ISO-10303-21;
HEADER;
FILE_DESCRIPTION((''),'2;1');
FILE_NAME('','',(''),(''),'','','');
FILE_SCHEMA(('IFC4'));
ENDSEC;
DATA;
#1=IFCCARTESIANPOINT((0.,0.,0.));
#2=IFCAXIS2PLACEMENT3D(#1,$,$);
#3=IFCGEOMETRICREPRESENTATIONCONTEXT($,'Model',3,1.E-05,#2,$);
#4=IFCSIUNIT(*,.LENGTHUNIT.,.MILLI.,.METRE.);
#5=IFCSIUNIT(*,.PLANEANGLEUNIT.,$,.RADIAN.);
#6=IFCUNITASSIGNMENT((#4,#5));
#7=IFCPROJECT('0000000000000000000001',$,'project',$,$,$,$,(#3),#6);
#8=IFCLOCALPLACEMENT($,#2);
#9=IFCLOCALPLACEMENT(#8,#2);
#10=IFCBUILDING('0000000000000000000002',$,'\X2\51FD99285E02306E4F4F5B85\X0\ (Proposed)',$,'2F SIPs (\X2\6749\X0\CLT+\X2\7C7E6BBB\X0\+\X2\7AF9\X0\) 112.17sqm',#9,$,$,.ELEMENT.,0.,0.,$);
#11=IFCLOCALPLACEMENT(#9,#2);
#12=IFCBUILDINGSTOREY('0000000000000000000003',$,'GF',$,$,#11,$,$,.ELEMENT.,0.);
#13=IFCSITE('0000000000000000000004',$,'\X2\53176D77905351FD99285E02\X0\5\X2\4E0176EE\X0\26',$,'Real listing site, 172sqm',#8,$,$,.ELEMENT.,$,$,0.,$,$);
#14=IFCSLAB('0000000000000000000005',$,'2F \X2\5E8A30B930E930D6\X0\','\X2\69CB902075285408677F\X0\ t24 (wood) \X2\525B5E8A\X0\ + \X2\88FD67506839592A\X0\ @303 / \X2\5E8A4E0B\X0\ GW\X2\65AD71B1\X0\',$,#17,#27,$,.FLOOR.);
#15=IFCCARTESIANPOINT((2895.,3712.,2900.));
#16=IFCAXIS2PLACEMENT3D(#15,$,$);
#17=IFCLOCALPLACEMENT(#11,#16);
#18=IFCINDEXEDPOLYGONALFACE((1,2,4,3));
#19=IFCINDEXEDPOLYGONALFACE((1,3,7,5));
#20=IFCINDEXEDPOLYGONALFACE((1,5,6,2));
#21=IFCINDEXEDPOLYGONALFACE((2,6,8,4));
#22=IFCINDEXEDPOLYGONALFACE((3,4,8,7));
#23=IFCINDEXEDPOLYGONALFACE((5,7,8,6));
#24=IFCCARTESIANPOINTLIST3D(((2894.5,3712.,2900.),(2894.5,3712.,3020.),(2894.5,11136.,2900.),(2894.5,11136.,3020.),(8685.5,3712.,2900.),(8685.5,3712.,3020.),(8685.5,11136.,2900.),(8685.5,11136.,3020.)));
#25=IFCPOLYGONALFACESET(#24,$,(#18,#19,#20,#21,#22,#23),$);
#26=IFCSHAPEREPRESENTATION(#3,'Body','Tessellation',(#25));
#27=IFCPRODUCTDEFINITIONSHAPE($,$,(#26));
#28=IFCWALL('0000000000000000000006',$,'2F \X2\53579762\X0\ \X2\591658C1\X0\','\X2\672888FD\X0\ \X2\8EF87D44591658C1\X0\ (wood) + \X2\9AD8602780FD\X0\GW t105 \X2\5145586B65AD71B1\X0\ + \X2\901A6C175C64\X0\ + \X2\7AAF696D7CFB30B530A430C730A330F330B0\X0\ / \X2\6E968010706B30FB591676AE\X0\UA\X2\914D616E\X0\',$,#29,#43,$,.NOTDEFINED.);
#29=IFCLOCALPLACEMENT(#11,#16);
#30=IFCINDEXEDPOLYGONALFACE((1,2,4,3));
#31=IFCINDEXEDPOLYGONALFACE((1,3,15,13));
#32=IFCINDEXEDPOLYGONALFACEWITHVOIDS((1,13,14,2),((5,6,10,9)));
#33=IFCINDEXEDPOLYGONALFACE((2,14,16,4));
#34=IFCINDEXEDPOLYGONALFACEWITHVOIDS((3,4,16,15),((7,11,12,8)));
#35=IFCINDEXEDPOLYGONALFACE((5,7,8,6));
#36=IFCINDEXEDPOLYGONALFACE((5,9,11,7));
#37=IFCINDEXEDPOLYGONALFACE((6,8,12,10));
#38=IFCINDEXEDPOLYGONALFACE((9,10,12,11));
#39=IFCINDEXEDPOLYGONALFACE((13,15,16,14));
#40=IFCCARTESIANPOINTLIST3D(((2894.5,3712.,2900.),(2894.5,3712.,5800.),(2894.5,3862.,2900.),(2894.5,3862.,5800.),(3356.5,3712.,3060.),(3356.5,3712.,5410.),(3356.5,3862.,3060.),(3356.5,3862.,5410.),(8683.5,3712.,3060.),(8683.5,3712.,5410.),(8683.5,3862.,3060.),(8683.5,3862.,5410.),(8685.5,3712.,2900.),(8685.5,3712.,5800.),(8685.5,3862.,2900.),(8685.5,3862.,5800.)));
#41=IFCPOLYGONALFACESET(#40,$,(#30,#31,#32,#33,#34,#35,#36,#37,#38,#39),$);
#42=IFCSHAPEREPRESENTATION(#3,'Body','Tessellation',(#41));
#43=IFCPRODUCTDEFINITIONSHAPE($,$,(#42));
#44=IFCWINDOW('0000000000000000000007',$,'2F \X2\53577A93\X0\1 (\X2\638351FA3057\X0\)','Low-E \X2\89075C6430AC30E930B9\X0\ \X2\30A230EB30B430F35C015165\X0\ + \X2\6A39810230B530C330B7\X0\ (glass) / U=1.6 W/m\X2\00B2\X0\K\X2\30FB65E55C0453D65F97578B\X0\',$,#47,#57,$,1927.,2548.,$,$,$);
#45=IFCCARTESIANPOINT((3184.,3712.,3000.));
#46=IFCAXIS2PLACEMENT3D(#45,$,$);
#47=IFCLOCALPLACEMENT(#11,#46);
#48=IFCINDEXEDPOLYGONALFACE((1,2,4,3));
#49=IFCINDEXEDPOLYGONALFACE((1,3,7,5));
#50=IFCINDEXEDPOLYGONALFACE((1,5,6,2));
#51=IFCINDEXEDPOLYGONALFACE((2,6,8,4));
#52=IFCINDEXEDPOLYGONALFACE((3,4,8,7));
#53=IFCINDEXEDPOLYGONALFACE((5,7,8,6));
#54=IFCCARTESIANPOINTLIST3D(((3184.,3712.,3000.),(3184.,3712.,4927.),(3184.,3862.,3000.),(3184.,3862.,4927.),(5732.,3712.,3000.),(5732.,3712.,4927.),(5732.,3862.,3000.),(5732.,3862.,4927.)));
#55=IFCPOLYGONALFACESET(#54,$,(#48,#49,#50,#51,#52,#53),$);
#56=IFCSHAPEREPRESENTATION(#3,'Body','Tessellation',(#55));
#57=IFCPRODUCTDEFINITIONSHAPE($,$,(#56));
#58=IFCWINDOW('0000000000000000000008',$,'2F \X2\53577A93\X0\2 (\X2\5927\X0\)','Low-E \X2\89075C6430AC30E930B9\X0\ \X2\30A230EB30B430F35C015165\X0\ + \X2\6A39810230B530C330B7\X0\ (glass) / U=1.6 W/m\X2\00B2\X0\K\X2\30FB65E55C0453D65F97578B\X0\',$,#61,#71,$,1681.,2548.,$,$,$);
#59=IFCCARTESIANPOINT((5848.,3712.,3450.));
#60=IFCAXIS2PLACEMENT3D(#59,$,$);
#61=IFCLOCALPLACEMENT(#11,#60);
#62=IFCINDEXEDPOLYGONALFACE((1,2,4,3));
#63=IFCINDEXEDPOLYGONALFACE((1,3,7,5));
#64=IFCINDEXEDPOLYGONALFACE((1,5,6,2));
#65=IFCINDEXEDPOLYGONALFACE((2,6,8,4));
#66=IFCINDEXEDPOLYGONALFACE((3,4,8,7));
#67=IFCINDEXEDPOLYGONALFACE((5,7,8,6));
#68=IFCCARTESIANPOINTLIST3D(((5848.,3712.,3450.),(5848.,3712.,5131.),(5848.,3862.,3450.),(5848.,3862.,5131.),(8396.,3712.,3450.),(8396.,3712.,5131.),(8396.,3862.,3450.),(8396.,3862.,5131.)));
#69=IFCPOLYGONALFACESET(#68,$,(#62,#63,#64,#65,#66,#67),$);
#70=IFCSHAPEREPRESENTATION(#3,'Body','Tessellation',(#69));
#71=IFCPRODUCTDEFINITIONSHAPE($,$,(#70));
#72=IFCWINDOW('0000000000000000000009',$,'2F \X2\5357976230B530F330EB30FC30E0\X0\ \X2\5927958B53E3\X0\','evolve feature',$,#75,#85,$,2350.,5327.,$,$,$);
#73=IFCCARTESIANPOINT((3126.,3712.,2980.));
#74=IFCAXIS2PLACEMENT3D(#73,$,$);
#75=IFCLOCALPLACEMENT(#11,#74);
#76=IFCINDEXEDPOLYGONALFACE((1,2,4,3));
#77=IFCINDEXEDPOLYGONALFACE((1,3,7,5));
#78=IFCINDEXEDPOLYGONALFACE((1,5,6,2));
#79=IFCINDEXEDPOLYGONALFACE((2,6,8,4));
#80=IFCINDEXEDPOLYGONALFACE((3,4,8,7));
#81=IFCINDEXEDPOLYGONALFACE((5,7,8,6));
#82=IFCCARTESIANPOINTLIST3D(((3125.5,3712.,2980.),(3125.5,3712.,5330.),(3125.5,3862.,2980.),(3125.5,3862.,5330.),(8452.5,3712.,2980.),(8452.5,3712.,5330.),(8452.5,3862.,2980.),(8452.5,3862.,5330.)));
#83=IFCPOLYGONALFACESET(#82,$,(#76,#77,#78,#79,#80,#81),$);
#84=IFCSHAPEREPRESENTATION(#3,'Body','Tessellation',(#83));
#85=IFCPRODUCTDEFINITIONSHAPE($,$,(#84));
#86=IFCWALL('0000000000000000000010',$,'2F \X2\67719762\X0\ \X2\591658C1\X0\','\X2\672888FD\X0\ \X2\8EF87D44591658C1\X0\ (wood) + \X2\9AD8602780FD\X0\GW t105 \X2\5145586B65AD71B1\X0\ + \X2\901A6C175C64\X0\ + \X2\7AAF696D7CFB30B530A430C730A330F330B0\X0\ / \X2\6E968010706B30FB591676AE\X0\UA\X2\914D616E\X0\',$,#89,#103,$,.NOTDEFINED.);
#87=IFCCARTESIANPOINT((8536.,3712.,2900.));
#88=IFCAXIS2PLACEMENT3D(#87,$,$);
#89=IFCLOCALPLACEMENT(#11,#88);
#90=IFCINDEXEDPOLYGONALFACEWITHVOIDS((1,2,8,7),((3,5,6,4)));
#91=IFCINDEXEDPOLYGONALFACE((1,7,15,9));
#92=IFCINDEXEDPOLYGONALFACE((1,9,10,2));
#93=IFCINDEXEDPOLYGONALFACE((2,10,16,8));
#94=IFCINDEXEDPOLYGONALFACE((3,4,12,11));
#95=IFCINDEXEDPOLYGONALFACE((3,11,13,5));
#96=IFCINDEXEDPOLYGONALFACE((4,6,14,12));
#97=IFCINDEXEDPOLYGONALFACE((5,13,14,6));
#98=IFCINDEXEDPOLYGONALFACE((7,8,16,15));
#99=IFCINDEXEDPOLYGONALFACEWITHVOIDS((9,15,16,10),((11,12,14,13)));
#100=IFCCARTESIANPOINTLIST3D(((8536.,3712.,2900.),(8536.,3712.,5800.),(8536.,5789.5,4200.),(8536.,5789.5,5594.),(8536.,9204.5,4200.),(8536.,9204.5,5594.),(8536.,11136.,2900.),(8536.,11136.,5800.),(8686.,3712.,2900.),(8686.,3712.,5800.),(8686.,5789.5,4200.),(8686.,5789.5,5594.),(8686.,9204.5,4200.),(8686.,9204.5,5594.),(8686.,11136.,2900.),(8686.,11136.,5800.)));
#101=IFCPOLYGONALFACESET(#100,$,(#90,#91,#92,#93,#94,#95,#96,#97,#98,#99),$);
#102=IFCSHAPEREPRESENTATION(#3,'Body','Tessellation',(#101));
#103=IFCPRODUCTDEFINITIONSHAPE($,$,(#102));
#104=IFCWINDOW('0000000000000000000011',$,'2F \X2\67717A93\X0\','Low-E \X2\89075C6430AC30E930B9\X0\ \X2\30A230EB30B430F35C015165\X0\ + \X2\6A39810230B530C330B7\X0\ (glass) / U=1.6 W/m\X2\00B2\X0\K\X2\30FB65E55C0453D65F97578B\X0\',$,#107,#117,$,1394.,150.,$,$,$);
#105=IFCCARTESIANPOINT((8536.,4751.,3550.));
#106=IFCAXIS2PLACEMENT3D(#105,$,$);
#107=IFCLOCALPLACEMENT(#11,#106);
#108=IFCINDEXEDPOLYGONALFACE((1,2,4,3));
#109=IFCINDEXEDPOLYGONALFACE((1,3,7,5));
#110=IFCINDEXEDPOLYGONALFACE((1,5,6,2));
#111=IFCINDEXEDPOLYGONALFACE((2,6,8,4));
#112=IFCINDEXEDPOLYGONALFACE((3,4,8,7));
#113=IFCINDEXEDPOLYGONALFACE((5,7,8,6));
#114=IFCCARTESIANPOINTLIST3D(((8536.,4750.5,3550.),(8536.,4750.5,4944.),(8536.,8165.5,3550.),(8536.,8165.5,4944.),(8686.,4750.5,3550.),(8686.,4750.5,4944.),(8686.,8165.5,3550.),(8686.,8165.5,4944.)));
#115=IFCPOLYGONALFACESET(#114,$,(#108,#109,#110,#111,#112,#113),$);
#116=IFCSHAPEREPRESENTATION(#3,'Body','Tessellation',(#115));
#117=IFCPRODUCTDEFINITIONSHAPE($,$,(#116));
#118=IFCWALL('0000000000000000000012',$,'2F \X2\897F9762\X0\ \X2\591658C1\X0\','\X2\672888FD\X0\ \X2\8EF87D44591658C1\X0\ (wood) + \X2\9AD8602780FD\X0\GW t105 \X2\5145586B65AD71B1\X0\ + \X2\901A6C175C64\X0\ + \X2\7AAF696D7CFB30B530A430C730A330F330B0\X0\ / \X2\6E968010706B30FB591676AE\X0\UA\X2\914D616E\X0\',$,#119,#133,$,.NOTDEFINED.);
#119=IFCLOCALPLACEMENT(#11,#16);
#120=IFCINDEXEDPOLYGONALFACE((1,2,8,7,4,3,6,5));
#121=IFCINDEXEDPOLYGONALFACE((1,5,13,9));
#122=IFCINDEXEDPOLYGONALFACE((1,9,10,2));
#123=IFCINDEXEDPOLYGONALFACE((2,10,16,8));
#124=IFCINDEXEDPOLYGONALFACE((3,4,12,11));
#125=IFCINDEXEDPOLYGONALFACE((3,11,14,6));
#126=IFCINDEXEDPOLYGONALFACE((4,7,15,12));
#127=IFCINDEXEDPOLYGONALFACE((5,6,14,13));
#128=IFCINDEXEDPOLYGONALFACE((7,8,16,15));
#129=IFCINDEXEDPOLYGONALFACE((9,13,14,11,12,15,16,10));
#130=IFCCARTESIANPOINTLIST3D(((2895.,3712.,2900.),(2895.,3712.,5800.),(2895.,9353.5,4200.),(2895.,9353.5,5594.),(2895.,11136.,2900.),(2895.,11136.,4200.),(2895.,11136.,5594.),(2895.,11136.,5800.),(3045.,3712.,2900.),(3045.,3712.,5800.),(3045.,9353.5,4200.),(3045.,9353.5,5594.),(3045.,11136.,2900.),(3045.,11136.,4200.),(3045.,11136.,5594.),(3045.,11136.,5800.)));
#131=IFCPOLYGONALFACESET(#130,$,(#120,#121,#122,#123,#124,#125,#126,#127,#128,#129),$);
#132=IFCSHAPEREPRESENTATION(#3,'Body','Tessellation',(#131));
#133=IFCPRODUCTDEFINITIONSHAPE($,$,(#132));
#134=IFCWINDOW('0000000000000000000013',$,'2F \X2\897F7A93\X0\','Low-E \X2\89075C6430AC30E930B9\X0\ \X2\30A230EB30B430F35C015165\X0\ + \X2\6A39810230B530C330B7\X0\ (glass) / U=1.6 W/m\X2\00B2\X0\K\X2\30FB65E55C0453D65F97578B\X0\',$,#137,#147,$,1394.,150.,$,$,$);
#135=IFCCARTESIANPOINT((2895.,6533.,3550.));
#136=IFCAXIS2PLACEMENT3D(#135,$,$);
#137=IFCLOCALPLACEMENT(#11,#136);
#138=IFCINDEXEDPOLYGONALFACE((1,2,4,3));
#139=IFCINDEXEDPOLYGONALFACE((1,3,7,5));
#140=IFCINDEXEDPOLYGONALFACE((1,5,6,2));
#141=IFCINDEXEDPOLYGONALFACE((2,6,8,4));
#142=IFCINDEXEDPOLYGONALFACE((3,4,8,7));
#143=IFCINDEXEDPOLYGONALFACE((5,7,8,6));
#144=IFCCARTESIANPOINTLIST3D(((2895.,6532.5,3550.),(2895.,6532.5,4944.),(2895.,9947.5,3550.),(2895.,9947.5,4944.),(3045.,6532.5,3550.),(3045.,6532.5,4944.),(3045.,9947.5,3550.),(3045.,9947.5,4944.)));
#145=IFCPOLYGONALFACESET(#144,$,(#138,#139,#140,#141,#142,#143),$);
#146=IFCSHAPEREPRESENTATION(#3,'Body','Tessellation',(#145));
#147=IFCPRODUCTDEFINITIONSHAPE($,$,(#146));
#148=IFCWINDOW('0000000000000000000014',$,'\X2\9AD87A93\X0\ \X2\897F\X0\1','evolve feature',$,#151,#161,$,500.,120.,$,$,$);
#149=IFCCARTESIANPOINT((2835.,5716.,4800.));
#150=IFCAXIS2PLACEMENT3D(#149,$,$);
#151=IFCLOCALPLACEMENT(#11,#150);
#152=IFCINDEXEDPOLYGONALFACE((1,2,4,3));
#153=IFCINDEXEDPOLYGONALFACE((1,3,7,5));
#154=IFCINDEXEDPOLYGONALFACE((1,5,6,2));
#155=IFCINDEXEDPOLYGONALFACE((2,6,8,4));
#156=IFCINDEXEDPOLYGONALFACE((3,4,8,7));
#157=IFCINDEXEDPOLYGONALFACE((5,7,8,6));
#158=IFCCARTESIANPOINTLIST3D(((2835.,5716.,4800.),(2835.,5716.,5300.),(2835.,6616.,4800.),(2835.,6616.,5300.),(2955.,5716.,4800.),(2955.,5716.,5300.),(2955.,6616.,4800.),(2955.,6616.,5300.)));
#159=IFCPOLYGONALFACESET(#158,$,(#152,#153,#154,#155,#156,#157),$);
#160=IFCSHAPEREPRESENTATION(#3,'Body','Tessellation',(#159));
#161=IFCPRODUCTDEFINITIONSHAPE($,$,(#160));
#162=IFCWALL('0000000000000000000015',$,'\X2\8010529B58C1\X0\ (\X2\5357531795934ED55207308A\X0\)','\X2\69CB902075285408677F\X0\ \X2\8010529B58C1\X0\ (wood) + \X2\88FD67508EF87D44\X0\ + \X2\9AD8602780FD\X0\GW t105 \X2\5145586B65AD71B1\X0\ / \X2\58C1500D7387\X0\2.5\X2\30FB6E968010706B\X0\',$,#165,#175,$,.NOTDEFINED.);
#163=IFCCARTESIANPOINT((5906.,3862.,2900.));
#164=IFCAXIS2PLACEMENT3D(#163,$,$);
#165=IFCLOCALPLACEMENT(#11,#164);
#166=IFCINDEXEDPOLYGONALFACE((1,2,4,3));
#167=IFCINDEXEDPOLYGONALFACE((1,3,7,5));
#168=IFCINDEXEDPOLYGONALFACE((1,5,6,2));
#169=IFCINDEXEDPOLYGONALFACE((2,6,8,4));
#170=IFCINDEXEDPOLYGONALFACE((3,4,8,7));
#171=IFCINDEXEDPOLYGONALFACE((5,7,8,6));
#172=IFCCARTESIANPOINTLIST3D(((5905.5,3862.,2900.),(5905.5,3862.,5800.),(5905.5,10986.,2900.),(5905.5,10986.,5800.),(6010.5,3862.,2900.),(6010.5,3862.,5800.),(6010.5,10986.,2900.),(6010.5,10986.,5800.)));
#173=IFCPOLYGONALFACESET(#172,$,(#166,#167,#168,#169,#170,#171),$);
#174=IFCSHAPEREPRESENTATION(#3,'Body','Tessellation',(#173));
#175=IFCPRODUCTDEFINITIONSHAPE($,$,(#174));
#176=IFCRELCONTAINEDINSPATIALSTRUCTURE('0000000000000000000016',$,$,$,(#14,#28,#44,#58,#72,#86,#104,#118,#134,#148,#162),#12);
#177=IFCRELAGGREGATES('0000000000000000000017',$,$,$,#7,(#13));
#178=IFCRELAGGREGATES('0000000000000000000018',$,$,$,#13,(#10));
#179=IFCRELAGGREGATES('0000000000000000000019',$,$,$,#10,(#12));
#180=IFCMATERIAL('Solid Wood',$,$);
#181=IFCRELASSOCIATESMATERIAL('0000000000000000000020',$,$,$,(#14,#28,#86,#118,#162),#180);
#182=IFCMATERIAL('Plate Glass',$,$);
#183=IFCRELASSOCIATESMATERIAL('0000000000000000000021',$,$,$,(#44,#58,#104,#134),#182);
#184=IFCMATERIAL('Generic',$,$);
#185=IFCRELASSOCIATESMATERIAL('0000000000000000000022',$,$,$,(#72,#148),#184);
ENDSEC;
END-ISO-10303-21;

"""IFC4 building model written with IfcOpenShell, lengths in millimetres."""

from ifc_helpers import new_model, si_unit, frame, frame_2d, origin, place, context, project, spatial, rectangle, extrude, material, element, fill, save


model = new_model("IFC4")

# Units and contexts
model_context = context("Model", 3, precision=1e-05, world=origin())
ifc_project = project(units=[si_unit("LENGTHUNIT", "METRE", prefix="MILLI"), si_unit("PLANEANGLEUNIT", "RADIAN")], contexts=[model_context])

# Site, building, storey
site_placement = place(None, origin())
site = spatial("IfcSite", under=ifc_project, at=site_placement, Name="北海道函館市5丁目26", ObjectType="Real listing site, 172sqm", CompositionType="ELEMENT", RefElevation=0.0)
building_placement = place(site_placement, origin())
building = spatial("IfcBuilding", under=site, at=building_placement, Name="函館市の住宅 (Proposed)", ObjectType="2F SIPs (杉CLT+籾殻+竹) 112.17sqm", CompositionType="ELEMENT", ElevationOfRefHeight=0.0, ElevationOfTerrain=0.0)
storey_placement = place(building_placement, origin())
storey = spatial("IfcBuildingStorey", under=building, at=storey_placement, Name="GF", CompositionType="ELEMENT", Elevation=0.0)

# Slab
ifc_material_1 = material(Name="Solid Wood")
slab_placement = place(storey_placement, frame((2895.0, 3712.0, 2900.0)))
element("IfcSlab", 1, at=slab_placement, inside=storey, material=ifc_material_1, Name="2F 床スラブ", Description="構造用合板 t24 (wood) 剛床 + 製材根太 @303 / 床下 GW断熱", PredefinedType="FLOOR", context=model_context, shape_type="SweptSolid", body=[
    extrude(rectangle(XDim=5791.0, YDim=7424.0, at=frame_2d((2895.0, 3712.0))), frame((2895.0, 3712.0, 2900.0)), (0.0, 0.0, 1.0), 120.0),
])

# Wall, openings, windows
wall_1_placement = place(storey_placement, frame((2895.0, 3712.0, 2900.0)))
wall_1 = element("IfcWall", 2, at=wall_1_placement, inside=storey, material=ifc_material_1, Name="2F 南面 外壁", Description="木製 軸組外壁 (wood) + 高性能GW t105 充填断熱 + 通気層 + 窯業系サイディング / 準耐火・外皮UA配慮", PredefinedType="NOTDEFINED", context=model_context, shape_type="SweptSolid", body=[
    extrude(rectangle(XDim=5791.0, YDim=150.0, at=frame_2d((2895.0, 75.0))), frame((2895.0, 3712.0, 2900.0)), (0.0, 0.0, 1.0), 2900.0),
])
opening_1_placement = place(storey_placement, frame((3184.0, 3712.0, 3000.0)))
opening_1 = element("IfcOpeningElement", 3, at=opening_1_placement, cuts=wall_1, PredefinedType="NOTDEFINED", context=model_context, shape_type="SweptSolid", body=[
    extrude(rectangle(XDim=2548.0, YDim=150.0, at=frame_2d((1274.0, 75.0))), frame((3184.0, 3712.0, 3000.0)), (0.0, 0.0, 1.0), 1927.0),
])
opening_2_placement = place(storey_placement, frame((5848.0, 3712.0, 3450.0)))
opening_2 = element("IfcOpeningElement", 4, at=opening_2_placement, cuts=wall_1, PredefinedType="NOTDEFINED", context=model_context, shape_type="SweptSolid", body=[
    extrude(rectangle(XDim=2548.0, YDim=150.0, at=frame_2d((1274.0, 75.0))), frame((5848.0, 3712.0, 3450.0)), (0.0, 0.0, 1.0), 1681.0),
])
opening_3_placement = place(storey_placement, frame((3126.0, 3712.0, 2980.0)))
opening_3 = element("IfcOpeningElement", 5, at=opening_3_placement, cuts=wall_1, PredefinedType="NOTDEFINED", context=model_context, shape_type="SweptSolid", body=[
    extrude(rectangle(XDim=5327.0, YDim=150.0, at=frame_2d((2663.0, 75.0))), frame((3126.0, 3712.0, 2980.0)), (0.0, 0.0, 1.0), 2350.0),
])
ifc_material_2 = material(Name="Plate Glass")
window_1_placement = place(storey_placement, frame((3184.0, 3712.0, 3000.0)))
window_1 = element("IfcWindow", 6, at=window_1_placement, inside=storey, material=ifc_material_2, Name="2F 南窓1 (掃出し)", Description="Low-E 複層ガラス アルゴン封入 + 樹脂サッシ (glass) / U=1.6 W/m²K・日射取得型", OverallHeight=1927.0, OverallWidth=2548.0, context=model_context, shape_type="SweptSolid", body=[
    extrude(rectangle(XDim=2548.0, YDim=150.0, at=frame_2d((1274.0, 75.0))), frame((3184.0, 3712.0, 3000.0)), (0.0, 0.0, 1.0), 1927.0),
])
fill(opening_1, window_1)
window_2_placement = place(storey_placement, frame((5848.0, 3712.0, 3450.0)))
window_2 = element("IfcWindow", 7, at=window_2_placement, inside=storey, material=ifc_material_2, Name="2F 南窓2 (大)", Description="Low-E 複層ガラス アルゴン封入 + 樹脂サッシ (glass) / U=1.6 W/m²K・日射取得型", OverallHeight=1681.0, OverallWidth=2548.0, context=model_context, shape_type="SweptSolid", body=[
    extrude(rectangle(XDim=2548.0, YDim=150.0, at=frame_2d((1274.0, 75.0))), frame((5848.0, 3712.0, 3450.0)), (0.0, 0.0, 1.0), 1681.0),
])
fill(opening_2, window_2)
ifc_material_3 = material(Name="Generic")
window_3_placement = place(storey_placement, frame((3126.0, 3712.0, 2980.0)))
window_3 = element("IfcWindow", 8, at=window_3_placement, inside=storey, material=ifc_material_3, Name="2F 南面サンルーム 大開口", Description="evolve feature", OverallHeight=2350.0, OverallWidth=5327.0, context=model_context, shape_type="SweptSolid", body=[
    extrude(rectangle(XDim=5327.0, YDim=150.0, at=frame_2d((2663.0, 75.0))), frame((3126.0, 3712.0, 2980.0)), (0.0, 0.0, 1.0), 2350.0),
])
fill(opening_3, window_3)

# Wall, opening, window
wall_2_placement = place(storey_placement, frame((8536.0, 3712.0, 2900.0)))
wall_2 = element("IfcWall", 9, at=wall_2_placement, inside=storey, material=ifc_material_1, Name="2F 東面 外壁", Description="木製 軸組外壁 (wood) + 高性能GW t105 充填断熱 + 通気層 + 窯業系サイディング / 準耐火・外皮UA配慮", PredefinedType="NOTDEFINED", context=model_context, shape_type="SweptSolid", body=[
    extrude(rectangle(XDim=150.0, YDim=7424.0, at=frame_2d((75.0, 3712.0))), frame((8536.0, 3712.0, 2900.0)), (0.0, 0.0, 1.0), 2900.0),
])
opening_4_placement = place(storey_placement, frame((8536.0, 4751.0, 3550.0)))
opening_4 = element("IfcOpeningElement", 10, at=opening_4_placement, cuts=wall_2, PredefinedType="NOTDEFINED", context=model_context, shape_type="SweptSolid", body=[
    extrude(rectangle(XDim=150.0, YDim=3415.0, at=frame_2d((75.0, 1707.0))), frame((8536.0, 4751.0, 3550.0)), (0.0, 0.0, 1.0), 1394.0),
])
window_4_placement = place(storey_placement, frame((8536.0, 4751.0, 3550.0)))
window_4 = element("IfcWindow", 11, at=window_4_placement, inside=storey, material=ifc_material_2, Name="2F 東窓", Description="Low-E 複層ガラス アルゴン封入 + 樹脂サッシ (glass) / U=1.6 W/m²K・日射取得型", OverallHeight=1394.0, OverallWidth=150.0, context=model_context, shape_type="SweptSolid", body=[
    extrude(rectangle(XDim=150.0, YDim=3415.0, at=frame_2d((75.0, 1707.0))), frame((8536.0, 4751.0, 3550.0)), (0.0, 0.0, 1.0), 1394.0),
])
fill(opening_4, window_4)

# Wall, openings, windows
wall_3_placement = place(storey_placement, frame((2895.0, 3712.0, 2900.0)))
wall_3 = element("IfcWall", 12, at=wall_3_placement, inside=storey, material=ifc_material_1, Name="2F 西面 外壁", Description="木製 軸組外壁 (wood) + 高性能GW t105 充填断熱 + 通気層 + 窯業系サイディング / 準耐火・外皮UA配慮", PredefinedType="NOTDEFINED", context=model_context, shape_type="SweptSolid", body=[
    extrude(rectangle(XDim=150.0, YDim=7424.0, at=frame_2d((75.0, 3712.0))), frame((2895.0, 3712.0, 2900.0)), (0.0, 0.0, 1.0), 2900.0),
])
opening_5_placement = place(storey_placement, frame((2895.0, 6533.0, 3550.0)))
opening_5 = element("IfcOpeningElement", 13, at=opening_5_placement, cuts=wall_3, PredefinedType="NOTDEFINED", context=model_context, shape_type="SweptSolid", body=[
    extrude(rectangle(XDim=150.0, YDim=3415.0, at=frame_2d((75.0, 1707.0))), frame((2895.0, 6533.0, 3550.0)), (0.0, 0.0, 1.0), 1394.0),
])
opening_6_placement = place(storey_placement, frame((2835.0, 5716.0, 4800.0)))
opening_6 = element("IfcOpeningElement", 14, at=opening_6_placement, cuts=wall_3, PredefinedType="NOTDEFINED", context=model_context, shape_type="SweptSolid", body=[
    extrude(rectangle(XDim=120.0, YDim=900.0, at=frame_2d((60.0, 450.0))), frame((2835.0, 5716.0, 4800.0)), (0.0, 0.0, 1.0), 500.0),
])
window_5_placement = place(storey_placement, frame((2895.0, 6533.0, 3550.0)))
window_5 = element("IfcWindow", 15, at=window_5_placement, inside=storey, material=ifc_material_2, Name="2F 西窓", Description="Low-E 複層ガラス アルゴン封入 + 樹脂サッシ (glass) / U=1.6 W/m²K・日射取得型", OverallHeight=1394.0, OverallWidth=150.0, context=model_context, shape_type="SweptSolid", body=[
    extrude(rectangle(XDim=150.0, YDim=3415.0, at=frame_2d((75.0, 1707.0))), frame((2895.0, 6533.0, 3550.0)), (0.0, 0.0, 1.0), 1394.0),
])
fill(opening_5, window_5)
window_6_placement = place(storey_placement, frame((2835.0, 5716.0, 4800.0)))
window_6 = element("IfcWindow", 16, at=window_6_placement, inside=storey, material=ifc_material_3, Name="高窓 西1", Description="evolve feature", OverallHeight=500.0, OverallWidth=120.0, context=model_context, shape_type="SweptSolid", body=[
    extrude(rectangle(XDim=120.0, YDim=900.0, at=frame_2d((60.0, 450.0))), frame((2835.0, 5716.0, 4800.0)), (0.0, 0.0, 1.0), 500.0),
])
fill(opening_6, window_6)

# Wall
wall_4_placement = place(storey_placement, frame((5906.0, 3862.0, 2900.0)))
element("IfcWall", 17, at=wall_4_placement, inside=storey, material=ifc_material_1, Name="耐力壁 (南北間仕切り)", Description="構造用合板 耐力壁 (wood) + 製材軸組 + 高性能GW t105 充填断熱 / 壁倍率2.5・準耐火", PredefinedType="NOTDEFINED", context=model_context, shape_type="SweptSolid", body=[
    extrude(rectangle(XDim=105.0, YDim=7124.0, at=frame_2d((52.0, 3562.0))), frame((5906.0, 3862.0, 2900.0)), (0.0, 0.0, 1.0), 2900.0),
])

save(model, "model.ifc")
